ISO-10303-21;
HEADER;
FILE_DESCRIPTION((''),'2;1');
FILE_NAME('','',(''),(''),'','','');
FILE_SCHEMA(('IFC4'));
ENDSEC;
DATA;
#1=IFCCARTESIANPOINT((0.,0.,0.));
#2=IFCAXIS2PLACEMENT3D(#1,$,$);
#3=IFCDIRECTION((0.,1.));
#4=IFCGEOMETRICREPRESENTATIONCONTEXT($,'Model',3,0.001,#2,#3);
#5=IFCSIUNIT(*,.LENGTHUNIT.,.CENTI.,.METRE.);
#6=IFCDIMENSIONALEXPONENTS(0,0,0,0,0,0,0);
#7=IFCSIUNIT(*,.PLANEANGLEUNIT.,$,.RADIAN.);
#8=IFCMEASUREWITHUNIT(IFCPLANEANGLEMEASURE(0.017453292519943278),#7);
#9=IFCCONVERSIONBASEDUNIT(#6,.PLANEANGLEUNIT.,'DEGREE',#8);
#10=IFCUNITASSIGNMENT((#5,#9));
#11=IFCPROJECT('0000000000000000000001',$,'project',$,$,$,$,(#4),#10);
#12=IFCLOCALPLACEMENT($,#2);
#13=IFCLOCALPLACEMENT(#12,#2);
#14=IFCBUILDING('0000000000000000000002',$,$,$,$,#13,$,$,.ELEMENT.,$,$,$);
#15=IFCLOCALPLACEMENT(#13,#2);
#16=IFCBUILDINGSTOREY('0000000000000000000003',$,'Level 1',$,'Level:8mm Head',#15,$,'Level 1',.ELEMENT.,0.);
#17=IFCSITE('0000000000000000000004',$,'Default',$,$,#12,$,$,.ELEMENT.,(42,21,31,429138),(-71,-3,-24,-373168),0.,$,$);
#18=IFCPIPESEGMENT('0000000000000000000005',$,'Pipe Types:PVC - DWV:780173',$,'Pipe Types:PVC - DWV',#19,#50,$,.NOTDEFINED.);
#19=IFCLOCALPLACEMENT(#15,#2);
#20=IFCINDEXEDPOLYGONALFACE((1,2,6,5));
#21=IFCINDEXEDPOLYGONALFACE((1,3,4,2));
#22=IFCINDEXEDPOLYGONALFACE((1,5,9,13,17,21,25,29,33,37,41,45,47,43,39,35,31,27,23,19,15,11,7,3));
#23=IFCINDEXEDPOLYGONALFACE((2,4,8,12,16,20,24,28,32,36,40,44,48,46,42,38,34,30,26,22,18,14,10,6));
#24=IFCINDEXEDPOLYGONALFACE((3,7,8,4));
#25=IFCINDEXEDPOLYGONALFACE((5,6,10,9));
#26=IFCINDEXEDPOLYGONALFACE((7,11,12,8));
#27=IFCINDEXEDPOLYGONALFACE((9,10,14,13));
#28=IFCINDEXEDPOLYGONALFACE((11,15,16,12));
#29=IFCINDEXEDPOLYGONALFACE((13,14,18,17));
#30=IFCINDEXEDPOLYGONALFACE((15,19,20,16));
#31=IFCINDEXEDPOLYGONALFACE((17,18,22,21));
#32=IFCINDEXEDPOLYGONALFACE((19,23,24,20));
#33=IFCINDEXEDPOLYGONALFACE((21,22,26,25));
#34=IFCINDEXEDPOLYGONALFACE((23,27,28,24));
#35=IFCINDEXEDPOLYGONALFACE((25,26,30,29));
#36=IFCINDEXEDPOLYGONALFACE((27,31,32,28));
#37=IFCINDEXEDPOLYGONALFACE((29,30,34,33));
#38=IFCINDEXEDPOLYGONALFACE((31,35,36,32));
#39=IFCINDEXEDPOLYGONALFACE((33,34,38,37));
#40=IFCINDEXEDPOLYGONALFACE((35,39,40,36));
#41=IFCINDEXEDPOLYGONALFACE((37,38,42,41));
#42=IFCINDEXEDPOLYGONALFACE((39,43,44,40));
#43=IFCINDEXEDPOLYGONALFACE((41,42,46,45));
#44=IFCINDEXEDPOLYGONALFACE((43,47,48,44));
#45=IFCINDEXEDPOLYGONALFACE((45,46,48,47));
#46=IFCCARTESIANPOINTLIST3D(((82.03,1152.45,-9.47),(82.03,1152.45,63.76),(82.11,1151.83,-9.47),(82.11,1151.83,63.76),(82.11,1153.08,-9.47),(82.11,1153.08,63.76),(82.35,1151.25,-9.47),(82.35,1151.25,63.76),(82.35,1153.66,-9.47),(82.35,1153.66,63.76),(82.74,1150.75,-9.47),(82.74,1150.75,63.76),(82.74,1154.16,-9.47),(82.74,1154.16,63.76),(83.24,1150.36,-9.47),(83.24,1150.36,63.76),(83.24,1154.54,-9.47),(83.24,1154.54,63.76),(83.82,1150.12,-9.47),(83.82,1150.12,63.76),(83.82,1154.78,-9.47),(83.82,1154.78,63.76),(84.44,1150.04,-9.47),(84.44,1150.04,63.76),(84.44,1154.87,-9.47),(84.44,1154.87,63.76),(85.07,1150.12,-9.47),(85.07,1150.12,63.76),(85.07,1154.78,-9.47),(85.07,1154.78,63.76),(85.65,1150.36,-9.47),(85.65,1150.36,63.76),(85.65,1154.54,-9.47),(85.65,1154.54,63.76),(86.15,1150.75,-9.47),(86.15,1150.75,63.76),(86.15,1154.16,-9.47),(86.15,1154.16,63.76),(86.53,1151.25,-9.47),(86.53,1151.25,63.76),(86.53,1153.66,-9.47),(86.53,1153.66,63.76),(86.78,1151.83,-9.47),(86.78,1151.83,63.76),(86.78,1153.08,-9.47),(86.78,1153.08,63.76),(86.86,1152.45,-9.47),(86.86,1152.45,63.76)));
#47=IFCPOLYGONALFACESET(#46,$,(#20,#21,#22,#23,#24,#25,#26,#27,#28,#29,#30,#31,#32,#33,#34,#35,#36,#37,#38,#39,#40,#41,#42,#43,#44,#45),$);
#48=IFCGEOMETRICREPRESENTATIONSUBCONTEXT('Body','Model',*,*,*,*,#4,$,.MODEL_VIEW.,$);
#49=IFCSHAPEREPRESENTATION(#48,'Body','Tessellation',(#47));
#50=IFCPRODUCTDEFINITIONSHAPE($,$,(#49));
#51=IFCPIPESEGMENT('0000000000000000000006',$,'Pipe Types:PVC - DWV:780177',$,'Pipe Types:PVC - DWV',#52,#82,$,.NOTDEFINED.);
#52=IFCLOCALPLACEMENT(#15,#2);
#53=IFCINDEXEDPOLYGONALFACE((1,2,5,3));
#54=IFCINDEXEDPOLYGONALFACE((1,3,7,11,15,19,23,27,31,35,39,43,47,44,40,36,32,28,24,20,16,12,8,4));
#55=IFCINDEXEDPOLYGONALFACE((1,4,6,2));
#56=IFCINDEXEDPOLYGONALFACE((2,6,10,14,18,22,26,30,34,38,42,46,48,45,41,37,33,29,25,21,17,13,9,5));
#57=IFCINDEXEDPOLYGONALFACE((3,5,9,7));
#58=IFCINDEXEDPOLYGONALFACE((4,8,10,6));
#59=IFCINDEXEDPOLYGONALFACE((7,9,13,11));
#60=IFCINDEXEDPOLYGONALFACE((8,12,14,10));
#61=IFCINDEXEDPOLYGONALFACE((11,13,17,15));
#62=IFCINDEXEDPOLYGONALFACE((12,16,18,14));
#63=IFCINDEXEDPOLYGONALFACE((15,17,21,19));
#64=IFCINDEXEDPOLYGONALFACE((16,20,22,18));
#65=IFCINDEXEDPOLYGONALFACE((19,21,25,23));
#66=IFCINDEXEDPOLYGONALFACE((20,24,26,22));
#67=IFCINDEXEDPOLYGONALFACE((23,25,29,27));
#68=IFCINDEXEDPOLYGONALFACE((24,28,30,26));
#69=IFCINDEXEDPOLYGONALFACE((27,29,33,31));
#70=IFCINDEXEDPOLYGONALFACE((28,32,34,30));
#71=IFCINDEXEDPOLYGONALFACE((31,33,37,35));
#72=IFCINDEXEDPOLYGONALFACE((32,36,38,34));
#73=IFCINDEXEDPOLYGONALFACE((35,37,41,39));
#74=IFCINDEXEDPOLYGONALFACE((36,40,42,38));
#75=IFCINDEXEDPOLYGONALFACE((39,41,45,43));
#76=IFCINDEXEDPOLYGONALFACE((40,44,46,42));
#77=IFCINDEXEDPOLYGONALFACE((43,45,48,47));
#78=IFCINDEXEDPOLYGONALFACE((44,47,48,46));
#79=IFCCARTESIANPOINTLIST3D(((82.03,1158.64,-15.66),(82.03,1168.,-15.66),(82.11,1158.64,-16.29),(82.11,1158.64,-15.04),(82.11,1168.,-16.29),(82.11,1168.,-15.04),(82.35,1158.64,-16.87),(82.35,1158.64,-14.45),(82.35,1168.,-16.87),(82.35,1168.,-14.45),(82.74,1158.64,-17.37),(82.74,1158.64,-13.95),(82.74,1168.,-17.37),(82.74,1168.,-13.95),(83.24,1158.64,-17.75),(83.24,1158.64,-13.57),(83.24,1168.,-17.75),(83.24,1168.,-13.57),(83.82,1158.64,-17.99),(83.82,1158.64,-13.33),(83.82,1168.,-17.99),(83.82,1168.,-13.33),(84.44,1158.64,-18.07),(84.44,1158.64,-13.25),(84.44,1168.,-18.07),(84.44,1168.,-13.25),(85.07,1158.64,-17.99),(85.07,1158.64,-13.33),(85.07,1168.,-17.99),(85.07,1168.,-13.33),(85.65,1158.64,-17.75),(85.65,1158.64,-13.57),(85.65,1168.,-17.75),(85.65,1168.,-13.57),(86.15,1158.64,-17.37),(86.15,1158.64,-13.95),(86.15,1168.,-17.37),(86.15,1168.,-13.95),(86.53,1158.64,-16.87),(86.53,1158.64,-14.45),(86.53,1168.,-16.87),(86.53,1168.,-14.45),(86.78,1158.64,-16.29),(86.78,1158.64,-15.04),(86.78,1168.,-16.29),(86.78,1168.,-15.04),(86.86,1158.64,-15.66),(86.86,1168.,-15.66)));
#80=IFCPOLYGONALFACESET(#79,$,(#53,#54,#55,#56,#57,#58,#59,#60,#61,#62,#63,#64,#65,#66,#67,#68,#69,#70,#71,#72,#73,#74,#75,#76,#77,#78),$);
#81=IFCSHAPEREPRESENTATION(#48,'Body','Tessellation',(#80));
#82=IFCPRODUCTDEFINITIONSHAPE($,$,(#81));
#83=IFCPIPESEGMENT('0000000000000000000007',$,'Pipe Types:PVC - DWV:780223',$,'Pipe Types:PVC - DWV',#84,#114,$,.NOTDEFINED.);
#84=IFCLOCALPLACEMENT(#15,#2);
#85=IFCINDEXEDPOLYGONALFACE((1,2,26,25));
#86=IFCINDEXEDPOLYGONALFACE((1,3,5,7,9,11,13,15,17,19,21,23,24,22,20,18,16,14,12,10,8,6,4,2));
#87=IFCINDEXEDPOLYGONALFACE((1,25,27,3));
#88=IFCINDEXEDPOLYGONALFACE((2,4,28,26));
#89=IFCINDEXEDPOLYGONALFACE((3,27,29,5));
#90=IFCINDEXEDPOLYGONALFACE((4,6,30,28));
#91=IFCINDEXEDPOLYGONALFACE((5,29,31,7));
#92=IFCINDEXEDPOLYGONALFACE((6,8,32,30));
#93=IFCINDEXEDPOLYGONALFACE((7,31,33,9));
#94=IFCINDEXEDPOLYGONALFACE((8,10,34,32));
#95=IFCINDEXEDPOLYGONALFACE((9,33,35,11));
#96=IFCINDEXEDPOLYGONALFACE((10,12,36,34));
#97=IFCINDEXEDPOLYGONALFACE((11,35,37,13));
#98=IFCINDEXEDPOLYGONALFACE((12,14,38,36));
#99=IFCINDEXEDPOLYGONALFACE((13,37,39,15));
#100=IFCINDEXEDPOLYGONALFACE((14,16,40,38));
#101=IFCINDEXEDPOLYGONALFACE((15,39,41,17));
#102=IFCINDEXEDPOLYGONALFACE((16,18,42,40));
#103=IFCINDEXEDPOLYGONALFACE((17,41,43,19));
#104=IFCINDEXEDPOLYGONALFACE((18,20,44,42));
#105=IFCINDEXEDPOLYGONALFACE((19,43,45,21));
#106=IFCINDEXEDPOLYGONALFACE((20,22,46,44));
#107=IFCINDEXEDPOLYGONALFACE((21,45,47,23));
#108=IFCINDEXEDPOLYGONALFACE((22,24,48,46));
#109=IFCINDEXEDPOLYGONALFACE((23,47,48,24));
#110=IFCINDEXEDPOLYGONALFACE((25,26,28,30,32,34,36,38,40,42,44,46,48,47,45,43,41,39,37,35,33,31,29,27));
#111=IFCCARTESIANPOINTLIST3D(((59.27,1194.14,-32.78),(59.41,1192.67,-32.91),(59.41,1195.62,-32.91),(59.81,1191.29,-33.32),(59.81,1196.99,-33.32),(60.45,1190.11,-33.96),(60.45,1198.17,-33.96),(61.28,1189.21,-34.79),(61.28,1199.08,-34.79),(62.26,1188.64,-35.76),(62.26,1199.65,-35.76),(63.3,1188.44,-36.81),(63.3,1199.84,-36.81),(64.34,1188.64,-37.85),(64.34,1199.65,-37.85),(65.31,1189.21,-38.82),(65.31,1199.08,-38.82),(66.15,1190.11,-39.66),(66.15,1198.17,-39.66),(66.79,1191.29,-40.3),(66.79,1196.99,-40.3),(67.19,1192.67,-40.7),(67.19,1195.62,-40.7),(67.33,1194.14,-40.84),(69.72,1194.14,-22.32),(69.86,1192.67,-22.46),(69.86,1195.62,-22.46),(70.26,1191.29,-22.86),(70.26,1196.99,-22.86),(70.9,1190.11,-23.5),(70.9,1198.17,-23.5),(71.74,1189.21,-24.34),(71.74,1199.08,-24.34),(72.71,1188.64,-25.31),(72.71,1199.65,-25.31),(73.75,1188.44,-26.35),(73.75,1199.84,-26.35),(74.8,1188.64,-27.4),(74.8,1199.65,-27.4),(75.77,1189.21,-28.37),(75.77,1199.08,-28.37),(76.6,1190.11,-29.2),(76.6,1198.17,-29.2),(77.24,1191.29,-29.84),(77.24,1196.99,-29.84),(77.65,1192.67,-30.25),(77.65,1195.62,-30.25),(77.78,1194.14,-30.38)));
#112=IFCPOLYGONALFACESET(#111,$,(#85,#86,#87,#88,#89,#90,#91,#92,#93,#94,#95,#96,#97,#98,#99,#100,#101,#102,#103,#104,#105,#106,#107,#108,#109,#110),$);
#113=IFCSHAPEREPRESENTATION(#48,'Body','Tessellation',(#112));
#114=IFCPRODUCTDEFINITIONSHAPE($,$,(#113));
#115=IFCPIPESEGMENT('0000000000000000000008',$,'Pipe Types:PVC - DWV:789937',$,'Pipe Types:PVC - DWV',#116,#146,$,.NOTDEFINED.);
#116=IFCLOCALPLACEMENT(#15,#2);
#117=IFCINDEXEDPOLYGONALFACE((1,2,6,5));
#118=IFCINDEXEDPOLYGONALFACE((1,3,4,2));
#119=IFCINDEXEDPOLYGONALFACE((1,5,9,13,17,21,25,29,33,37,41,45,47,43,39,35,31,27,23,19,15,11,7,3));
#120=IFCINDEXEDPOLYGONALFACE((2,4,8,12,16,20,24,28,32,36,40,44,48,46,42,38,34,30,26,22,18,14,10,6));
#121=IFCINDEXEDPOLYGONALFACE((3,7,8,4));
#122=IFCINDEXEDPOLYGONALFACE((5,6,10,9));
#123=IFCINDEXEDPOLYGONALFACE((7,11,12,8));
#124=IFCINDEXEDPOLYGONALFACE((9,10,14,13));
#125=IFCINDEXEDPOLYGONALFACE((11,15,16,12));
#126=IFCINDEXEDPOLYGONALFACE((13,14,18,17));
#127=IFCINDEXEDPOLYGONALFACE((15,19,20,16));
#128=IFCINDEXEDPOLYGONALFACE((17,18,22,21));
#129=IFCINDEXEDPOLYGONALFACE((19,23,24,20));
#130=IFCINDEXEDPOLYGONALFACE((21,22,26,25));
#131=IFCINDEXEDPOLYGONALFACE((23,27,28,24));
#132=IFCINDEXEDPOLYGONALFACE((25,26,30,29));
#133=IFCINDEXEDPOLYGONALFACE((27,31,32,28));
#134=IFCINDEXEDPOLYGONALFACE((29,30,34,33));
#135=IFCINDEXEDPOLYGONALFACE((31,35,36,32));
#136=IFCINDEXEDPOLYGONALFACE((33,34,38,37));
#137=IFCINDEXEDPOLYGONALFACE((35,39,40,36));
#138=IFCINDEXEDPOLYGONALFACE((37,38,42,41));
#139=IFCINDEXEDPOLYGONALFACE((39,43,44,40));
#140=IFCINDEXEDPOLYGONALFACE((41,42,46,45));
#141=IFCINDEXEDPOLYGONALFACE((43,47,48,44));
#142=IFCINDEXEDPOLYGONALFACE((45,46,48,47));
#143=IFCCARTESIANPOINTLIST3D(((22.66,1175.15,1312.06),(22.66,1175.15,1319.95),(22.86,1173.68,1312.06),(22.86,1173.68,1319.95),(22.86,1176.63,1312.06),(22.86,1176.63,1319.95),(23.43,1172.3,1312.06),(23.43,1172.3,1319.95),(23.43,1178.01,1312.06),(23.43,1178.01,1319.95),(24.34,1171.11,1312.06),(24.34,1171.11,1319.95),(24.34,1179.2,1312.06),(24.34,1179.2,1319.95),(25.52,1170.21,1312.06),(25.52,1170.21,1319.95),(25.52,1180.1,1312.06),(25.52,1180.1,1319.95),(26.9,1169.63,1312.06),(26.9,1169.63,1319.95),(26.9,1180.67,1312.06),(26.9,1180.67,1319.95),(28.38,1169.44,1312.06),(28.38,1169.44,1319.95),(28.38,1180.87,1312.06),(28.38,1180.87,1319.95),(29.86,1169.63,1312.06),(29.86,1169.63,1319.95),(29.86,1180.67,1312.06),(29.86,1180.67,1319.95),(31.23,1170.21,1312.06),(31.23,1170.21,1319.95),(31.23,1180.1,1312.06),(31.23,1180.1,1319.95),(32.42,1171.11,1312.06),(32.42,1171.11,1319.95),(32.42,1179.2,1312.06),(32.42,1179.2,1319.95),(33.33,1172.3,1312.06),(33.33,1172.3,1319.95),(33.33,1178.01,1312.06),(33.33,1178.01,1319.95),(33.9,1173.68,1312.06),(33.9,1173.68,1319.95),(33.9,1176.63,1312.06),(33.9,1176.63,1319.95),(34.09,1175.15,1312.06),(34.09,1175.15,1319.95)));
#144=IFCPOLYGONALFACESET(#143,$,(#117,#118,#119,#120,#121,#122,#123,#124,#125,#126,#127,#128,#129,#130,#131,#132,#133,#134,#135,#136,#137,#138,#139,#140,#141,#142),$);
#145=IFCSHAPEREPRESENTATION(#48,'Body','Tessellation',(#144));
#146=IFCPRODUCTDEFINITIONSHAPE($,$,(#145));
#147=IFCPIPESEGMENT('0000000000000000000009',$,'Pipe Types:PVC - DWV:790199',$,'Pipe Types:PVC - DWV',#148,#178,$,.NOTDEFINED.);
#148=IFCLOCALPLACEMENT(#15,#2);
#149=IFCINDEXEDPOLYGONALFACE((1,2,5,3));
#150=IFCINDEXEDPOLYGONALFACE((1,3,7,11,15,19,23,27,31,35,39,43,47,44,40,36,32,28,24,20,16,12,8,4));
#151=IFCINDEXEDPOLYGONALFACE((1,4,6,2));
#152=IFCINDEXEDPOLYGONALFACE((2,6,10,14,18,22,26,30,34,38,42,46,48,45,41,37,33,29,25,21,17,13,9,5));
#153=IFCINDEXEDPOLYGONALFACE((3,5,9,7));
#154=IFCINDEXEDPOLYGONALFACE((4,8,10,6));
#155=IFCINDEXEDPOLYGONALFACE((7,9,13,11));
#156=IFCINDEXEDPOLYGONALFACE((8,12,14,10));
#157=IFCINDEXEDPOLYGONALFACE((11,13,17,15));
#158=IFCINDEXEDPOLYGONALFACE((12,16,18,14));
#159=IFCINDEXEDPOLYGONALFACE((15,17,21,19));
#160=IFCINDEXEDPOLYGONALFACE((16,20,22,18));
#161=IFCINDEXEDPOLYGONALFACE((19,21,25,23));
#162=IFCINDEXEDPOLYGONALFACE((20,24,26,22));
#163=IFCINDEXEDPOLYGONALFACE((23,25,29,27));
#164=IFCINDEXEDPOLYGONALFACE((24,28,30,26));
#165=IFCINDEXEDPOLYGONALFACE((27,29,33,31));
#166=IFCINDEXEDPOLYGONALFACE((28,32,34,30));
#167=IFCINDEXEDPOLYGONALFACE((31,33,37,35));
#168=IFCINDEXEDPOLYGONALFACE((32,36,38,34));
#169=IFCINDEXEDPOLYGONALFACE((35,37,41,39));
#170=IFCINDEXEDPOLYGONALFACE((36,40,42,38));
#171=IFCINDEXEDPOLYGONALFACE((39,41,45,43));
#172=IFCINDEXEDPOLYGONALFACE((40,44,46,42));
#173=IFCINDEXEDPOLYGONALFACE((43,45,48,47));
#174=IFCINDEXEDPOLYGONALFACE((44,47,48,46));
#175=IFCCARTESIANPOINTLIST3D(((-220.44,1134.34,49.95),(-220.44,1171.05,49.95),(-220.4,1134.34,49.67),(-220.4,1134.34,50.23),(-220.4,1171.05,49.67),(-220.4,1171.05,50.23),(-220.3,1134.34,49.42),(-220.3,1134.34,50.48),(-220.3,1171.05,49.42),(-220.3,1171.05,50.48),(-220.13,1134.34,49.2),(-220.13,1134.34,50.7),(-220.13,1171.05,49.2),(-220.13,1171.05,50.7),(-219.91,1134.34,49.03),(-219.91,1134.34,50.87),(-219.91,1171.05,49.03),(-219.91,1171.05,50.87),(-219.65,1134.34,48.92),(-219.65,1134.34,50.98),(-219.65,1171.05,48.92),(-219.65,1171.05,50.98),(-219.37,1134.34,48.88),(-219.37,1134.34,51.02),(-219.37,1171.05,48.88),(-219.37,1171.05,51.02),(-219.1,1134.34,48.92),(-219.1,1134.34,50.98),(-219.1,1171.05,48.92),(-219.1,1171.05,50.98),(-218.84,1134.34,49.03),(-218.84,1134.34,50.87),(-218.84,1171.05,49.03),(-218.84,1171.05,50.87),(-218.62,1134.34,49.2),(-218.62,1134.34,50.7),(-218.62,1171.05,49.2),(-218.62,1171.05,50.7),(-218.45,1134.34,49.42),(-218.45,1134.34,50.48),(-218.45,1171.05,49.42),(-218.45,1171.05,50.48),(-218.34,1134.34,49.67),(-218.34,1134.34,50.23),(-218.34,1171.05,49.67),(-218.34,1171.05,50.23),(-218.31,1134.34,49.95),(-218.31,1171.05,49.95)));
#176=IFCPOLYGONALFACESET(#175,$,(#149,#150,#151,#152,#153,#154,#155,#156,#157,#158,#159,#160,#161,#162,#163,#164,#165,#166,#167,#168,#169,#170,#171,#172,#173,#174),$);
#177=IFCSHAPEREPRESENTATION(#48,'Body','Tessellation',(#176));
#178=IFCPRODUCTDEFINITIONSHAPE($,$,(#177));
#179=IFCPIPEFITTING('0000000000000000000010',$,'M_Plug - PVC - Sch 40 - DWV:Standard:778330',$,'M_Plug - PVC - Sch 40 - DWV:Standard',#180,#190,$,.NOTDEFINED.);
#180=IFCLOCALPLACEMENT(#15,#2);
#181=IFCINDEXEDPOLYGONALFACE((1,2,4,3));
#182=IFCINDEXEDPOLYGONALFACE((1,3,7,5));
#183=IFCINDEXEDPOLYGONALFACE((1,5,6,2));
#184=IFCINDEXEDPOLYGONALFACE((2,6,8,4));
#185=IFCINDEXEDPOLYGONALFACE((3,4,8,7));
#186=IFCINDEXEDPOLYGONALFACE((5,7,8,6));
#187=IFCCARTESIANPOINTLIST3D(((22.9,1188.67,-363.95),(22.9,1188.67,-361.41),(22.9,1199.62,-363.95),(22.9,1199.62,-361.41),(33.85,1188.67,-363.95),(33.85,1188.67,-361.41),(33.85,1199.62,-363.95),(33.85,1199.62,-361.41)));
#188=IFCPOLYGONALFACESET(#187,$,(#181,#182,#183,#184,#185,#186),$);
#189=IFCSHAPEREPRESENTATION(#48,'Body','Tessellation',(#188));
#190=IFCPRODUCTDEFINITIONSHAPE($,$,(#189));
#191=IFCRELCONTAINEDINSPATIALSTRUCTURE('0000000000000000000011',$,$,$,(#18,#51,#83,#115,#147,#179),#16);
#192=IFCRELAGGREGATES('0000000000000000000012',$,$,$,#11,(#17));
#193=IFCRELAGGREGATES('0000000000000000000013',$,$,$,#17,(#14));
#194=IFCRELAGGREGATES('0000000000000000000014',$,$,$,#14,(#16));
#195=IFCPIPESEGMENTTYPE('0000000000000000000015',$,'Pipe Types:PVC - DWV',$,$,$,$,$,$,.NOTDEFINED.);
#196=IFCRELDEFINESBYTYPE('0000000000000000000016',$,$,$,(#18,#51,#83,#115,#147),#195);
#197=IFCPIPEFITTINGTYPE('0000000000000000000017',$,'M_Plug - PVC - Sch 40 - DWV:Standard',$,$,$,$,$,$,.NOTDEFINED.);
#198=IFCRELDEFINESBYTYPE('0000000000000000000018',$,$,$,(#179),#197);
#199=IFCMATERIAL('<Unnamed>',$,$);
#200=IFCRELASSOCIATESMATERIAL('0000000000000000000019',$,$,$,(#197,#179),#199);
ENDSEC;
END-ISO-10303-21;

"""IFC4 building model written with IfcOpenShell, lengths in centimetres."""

from ifc_helpers import new_model, entity, si_unit, converted_unit, direction, frame, origin, place, context, subcontext, project, spatial, arc, indexed_curve, outline, extrude, source, transform, mapped, material, type_object, type_shapes, element, save


model = new_model("IFC4")

# Units and contexts
model_context = context("Model", 3, precision=0.001, world=origin(), true_north=direction((0.0, 1.0)))
body_context = subcontext(model_context, "Body", "Model", "MODEL_VIEW")
ifc_project = project(units=[si_unit("LENGTHUNIT", "METRE", prefix="CENTI"), converted_unit("PLANEANGLEUNIT", "DEGREE", entity("IfcPlaneAngleMeasure", 0.017453292519943278), si_unit("PLANEANGLEUNIT", "RADIAN"), dimensions=[0, 0, 0, 0, 0, 0, 0])], contexts=[model_context])

# Site, building, storey
site_placement = place(None, origin())
site = spatial("IfcSite", under=ifc_project, at=site_placement, Name="Default", CompositionType="ELEMENT", RefLatitude=(42, 21, 31, 429138), RefLongitude=(-71, -3, -24, -373168), RefElevation=0.0)
building_placement = place(site_placement, origin())
building = spatial("IfcBuilding", under=site, at=building_placement, CompositionType="ELEMENT")
storey_placement = place(building_placement, origin())
storey = spatial("IfcBuildingStorey", under=building, at=storey_placement, Name="Level 1", ObjectType="Level:8mm Head", LongName="Level 1", CompositionType="ELEMENT", Elevation=0.0)

# Pipe segments
pipe_segment_type = type_object("IfcPipeSegmentType", Name="Pipe Types:PVC - DWV", PredefinedType="NOTDEFINED")
pipe_segment_1_placement = place(storey_placement, origin())
element("IfcPipeSegment", 1, at=pipe_segment_1_placement, inside=storey, type_object=pipe_segment_type, Name="Pipe Types:PVC - DWV:780173", ObjectType="Pipe Types:PVC - DWV", PredefinedType="NOTDEFINED", context=body_context, shape_type="SweptSolid", body=[
    extrude(outline(indexed_curve([(2.41, 0.0), (1.71, 1.71), (0.0, 2.41), (-1.71, 1.71), (-2.41, 0.0), (-1.71, -1.71), (0.0, -2.41), (1.71, -1.71)], segments=[arc(1, 2, 3), arc(3, 4, 5), arc(5, 6, 7), arc(7, 8, 1)], self_intersect=False)), frame((84.44, 1152.45, -9.47)), (0.0, 0.0, 1.0), 73.23),
])
pipe_segment_2_placement = place(storey_placement, origin())
element("IfcPipeSegment", 2, at=pipe_segment_2_placement, inside=storey, type_object=pipe_segment_type, Name="Pipe Types:PVC - DWV:780177", ObjectType="Pipe Types:PVC - DWV", PredefinedType="NOTDEFINED", context=body_context, shape_type="SweptSolid", body=[
    extrude(outline(indexed_curve([(2.41, 0.0), (1.71, 1.71), (0.0, 2.41), (-1.71, 1.71), (-2.41, 0.0), (-1.71, -1.71), (0.0, -2.41), (1.71, -1.71)], segments=[arc(1, 2, 3), arc(3, 4, 5), arc(5, 6, 7), arc(7, 8, 1)], self_intersect=False)), frame((84.44, 1158.64, -15.66), z_axis=(0.0, 1.0, 0.0), x_axis=(1.0, 0.0, 0.0)), (0.0, 0.0, 1.0), 9.36),
])
pipe_segment_3_placement = place(storey_placement, origin())
element("IfcPipeSegment", 3, at=pipe_segment_3_placement, inside=storey, type_object=pipe_segment_type, Name="Pipe Types:PVC - DWV:780223", ObjectType="Pipe Types:PVC - DWV", PredefinedType="NOTDEFINED", context=body_context, shape_type="SweptSolid", body=[
    extrude(outline(indexed_curve([(5.7, 0.0), (4.03, 4.03), (0.0, 5.7), (-4.03, 4.03), (-5.7, 0.0), (-4.03, -4.03), (0.0, -5.7), (4.03, -4.03)], segments=[arc(1, 2, 3), arc(3, 4, 5), arc(5, 6, 7), arc(7, 8, 1)], self_intersect=False)), frame((63.3, 1194.14, -36.81), z_axis=(0.707107, 0.0, 0.707107), x_axis=(0.0, -1.0, 0.0)), (0.0, 0.0, 1.0), 14.78),
])
pipe_segment_4_placement = place(storey_placement, origin())
element("IfcPipeSegment", 4, at=pipe_segment_4_placement, inside=storey, type_object=pipe_segment_type, Name="Pipe Types:PVC - DWV:789937", ObjectType="Pipe Types:PVC - DWV", PredefinedType="NOTDEFINED", context=body_context, shape_type="SweptSolid", body=[
    extrude(outline(indexed_curve([(5.72, 0.0), (4.04, 4.04), (0.0, 5.71), (-4.04, 4.04), (-5.71, 0.0), (-4.04, -4.04), (0.0, -5.71), (4.04, -4.04)], segments=[arc(1, 2, 3), arc(3, 4, 5), arc(5, 6, 7), arc(7, 8, 1)], self_intersect=False)), frame((28.38, 1175.15, 1312.06), z_axis=(0.0, 0.0, 1.0), x_axis=(-1.0, 0.0, 0.0)), (0.0, 0.0, 1.0), 7.88),
])
pipe_segment_5_placement = place(storey_placement, origin())
element("IfcPipeSegment", 5, at=pipe_segment_5_placement, inside=storey, type_object=pipe_segment_type, Name="Pipe Types:PVC - DWV:790199", ObjectType="Pipe Types:PVC - DWV", PredefinedType="NOTDEFINED", context=body_context, shape_type="SweptSolid", body=[
    extrude(outline(indexed_curve([(1.07, 0.0), (0.75, 0.75), (0.0, 1.07), (-0.75, 0.75), (-1.07, 0.0), (-0.75, -0.75), (0.0, -1.07), (0.75, -0.75)], segments=[arc(1, 2, 3), arc(3, 4, 5), arc(5, 6, 7), arc(7, 8, 1)], self_intersect=False)), frame((-219.37, 1134.34, 49.95), z_axis=(0.0, 1.0, 0.0), x_axis=(1.0, 0.0, 0.0)), (0.0, 0.0, 1.0), 36.71),
])

# Pipe fitting
ifc_material = material(Name="<Unnamed>")
pipe_fitting_type_1 = type_object("IfcPipeFittingType", Name="M_Plug - PVC - Sch 40 - DWV:Standard", PredefinedType="NOTDEFINED", material=ifc_material)
shared_shape_1 = source(origin(), body_context, "Body", "SweptSolid", [
    extrude(outline(indexed_curve([(-1.27, -5.48), (1.27, -5.48), (1.27, 5.48), (-1.27, 5.48), (-1.27, -5.48)], self_intersect=False)), frame((1.27, 0.0, -5.48), z_axis=(0.0, 0.0, 1.0), x_axis=(-1.0, 0.0, 0.0)), (0.0, 0.0, 1.0), 10.95),
])
type_shapes(pipe_fitting_type_1, [shared_shape_1])
pipe_fitting_placement = place(storey_placement, frame((28.38, 1194.14, -361.41), z_axis=(1.0, 0.0, 0.0), x_axis=(0.0, 0.0, -1.0)))
element("IfcPipeFitting", 6, at=pipe_fitting_placement, inside=storey, type_object=pipe_fitting_type_1, material=ifc_material, Name="M_Plug - PVC - Sch 40 - DWV:Standard:778330", ObjectType="M_Plug - PVC - Sch 40 - DWV:Standard", PredefinedType="NOTDEFINED", context=body_context, shape_type="MappedRepresentation", body=[
    mapped(shared_shape_1, transform((0.0, 0.0, 0.0), scale=1.0)),
])

save(model, "model.ifc")
